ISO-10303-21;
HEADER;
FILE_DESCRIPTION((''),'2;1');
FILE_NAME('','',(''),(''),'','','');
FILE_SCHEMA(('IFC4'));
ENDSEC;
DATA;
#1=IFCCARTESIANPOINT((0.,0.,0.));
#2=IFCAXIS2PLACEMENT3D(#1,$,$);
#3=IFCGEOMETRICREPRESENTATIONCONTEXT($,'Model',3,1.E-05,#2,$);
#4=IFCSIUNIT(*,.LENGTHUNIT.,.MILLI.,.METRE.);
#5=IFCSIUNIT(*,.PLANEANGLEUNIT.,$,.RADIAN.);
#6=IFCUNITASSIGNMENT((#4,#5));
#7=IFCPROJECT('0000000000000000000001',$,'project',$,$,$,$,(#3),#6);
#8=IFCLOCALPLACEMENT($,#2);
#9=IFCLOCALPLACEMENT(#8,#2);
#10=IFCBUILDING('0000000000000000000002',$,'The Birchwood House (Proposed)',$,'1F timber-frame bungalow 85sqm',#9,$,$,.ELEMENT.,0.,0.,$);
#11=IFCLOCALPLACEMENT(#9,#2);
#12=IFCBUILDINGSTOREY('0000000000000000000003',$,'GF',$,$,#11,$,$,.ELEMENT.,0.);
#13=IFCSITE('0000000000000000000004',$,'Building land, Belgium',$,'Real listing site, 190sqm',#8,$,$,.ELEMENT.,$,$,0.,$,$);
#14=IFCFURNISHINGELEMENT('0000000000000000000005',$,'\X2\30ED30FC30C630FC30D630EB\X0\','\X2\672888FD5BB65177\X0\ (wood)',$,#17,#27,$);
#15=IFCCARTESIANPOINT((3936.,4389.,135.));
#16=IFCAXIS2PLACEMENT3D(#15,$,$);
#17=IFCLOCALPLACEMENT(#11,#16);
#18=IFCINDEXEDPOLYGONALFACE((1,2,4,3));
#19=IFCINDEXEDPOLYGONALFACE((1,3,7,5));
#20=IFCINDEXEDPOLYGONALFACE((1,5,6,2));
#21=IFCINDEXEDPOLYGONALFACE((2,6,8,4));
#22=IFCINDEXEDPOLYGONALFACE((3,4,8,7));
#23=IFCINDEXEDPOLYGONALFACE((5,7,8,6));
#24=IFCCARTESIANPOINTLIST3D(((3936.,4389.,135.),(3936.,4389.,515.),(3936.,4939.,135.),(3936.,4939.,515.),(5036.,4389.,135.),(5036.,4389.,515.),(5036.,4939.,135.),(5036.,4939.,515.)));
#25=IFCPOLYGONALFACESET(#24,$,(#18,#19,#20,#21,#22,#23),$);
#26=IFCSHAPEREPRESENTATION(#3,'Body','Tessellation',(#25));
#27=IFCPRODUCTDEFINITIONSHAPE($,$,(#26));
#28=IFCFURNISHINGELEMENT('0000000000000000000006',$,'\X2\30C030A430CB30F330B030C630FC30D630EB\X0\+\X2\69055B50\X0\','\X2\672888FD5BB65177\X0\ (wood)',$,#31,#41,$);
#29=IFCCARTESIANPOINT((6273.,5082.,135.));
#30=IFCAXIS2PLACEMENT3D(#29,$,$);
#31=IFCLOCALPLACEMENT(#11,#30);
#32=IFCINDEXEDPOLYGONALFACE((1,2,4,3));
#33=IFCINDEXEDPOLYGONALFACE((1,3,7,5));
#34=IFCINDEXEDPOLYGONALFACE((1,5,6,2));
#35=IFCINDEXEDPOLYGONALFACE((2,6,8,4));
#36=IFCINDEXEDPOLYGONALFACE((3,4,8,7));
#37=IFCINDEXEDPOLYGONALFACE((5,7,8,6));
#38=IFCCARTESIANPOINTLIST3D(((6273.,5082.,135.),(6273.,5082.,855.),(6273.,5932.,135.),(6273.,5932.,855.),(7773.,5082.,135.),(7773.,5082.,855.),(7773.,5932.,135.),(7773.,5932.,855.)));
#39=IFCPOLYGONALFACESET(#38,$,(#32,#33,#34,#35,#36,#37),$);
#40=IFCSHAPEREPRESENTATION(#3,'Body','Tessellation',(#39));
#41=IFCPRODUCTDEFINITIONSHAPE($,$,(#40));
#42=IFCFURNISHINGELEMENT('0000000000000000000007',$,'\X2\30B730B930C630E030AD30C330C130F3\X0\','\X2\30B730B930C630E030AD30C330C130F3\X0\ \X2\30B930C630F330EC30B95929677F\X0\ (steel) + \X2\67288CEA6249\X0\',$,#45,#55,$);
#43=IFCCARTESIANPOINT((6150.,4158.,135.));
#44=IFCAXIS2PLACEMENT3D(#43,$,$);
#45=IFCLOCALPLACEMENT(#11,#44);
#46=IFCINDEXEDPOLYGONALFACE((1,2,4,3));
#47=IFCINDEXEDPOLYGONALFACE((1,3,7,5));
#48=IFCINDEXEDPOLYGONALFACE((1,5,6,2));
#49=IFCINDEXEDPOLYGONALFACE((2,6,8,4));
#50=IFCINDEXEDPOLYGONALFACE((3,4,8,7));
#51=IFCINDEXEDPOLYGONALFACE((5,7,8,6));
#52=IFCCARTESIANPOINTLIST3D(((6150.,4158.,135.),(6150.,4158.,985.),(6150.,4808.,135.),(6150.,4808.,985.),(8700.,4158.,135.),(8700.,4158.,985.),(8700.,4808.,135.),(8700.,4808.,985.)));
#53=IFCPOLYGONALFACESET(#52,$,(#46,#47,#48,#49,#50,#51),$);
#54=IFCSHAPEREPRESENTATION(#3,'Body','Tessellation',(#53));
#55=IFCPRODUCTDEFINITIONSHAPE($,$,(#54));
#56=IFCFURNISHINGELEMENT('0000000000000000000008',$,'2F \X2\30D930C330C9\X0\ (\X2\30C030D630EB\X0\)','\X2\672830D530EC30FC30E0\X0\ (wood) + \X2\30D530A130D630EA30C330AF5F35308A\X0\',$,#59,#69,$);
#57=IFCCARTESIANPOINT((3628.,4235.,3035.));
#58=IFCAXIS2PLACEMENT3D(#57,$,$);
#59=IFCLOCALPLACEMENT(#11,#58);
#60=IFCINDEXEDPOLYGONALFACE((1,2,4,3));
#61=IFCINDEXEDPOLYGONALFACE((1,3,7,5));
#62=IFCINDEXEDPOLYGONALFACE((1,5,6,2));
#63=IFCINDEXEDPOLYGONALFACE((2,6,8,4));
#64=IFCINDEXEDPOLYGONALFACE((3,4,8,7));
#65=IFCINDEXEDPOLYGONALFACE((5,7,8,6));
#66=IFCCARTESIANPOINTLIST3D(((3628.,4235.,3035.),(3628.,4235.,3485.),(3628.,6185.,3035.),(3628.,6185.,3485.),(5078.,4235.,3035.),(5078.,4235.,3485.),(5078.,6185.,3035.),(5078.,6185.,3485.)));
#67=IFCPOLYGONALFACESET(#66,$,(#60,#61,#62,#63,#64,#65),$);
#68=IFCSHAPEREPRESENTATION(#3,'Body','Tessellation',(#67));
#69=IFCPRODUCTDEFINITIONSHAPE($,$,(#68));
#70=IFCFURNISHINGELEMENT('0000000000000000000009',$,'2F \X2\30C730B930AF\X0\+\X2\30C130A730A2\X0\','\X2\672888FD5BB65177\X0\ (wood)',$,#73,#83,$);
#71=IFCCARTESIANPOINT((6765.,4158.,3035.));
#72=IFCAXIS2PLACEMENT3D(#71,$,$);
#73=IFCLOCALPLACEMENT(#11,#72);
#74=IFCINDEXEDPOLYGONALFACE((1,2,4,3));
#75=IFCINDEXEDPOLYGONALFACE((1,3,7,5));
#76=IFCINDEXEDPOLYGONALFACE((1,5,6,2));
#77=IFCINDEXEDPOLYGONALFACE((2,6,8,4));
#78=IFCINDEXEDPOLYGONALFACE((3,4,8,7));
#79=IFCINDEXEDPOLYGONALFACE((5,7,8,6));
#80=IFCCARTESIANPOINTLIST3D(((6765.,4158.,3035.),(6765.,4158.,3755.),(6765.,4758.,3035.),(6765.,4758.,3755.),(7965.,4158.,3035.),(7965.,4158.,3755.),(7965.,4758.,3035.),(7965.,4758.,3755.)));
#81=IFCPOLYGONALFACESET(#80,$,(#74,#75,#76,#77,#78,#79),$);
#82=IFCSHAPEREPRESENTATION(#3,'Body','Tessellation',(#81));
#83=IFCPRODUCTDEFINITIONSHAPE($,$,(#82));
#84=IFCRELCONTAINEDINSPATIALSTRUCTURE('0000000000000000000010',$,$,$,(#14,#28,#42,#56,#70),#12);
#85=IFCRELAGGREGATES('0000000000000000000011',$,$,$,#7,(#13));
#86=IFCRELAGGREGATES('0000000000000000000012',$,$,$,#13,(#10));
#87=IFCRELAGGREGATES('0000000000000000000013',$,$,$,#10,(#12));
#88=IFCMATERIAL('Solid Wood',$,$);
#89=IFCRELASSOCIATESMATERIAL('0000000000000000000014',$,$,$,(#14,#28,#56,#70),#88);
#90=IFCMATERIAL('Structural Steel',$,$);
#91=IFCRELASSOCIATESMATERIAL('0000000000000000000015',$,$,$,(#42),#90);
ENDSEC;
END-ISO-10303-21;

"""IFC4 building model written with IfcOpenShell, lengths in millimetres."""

from ifc_helpers import new_model, si_unit, frame, frame_2d, origin, place, context, project, spatial, rectangle, extrude, material, element, save


model = new_model("IFC4")

# Units and contexts
model_context = context("Model", 3, precision=1e-05, world=origin())
ifc_project = project(units=[si_unit("LENGTHUNIT", "METRE", prefix="MILLI"), si_unit("PLANEANGLEUNIT", "RADIAN")], contexts=[model_context])

# Site, building, storey
site_placement = place(None, origin())
site = spatial("IfcSite", under=ifc_project, at=site_placement, Name="Building land, Belgium", ObjectType="Real listing site, 190sqm", CompositionType="ELEMENT", RefElevation=0.0)
building_placement = place(site_placement, origin())
building = spatial("IfcBuilding", under=site, at=building_placement, Name="The Birchwood House (Proposed)", ObjectType="1F timber-frame bungalow 85sqm", CompositionType="ELEMENT", ElevationOfRefHeight=0.0, ElevationOfTerrain=0.0)
storey_placement = place(building_placement, origin())
storey = spatial("IfcBuildingStorey", under=building, at=storey_placement, Name="GF", CompositionType="ELEMENT", Elevation=0.0)

# Shared definitions
ifc_material_1 = material(Name="Solid Wood")

# Shared definitions
ifc_material_2 = material(Name="Structural Steel")

# Furnishing elements
furnishing_1_placement = place(storey_placement, frame((3936.0, 4389.0, 135.0)))
element("IfcFurnishingElement", 1, at=furnishing_1_placement, inside=storey, material=ifc_material_1, Name="ローテーブル", Description="木製家具 (wood)", context=model_context, shape_type="SweptSolid", body=[
    extrude(rectangle(XDim=1100.0, YDim=550.0, at=frame_2d((550.0, 275.0))), frame((3936.0, 4389.0, 135.0)), (0.0, 0.0, 1.0), 380.0),
])
furnishing_2_placement = place(storey_placement, frame((6273.0, 5082.0, 135.0)))
element("IfcFurnishingElement", 2, at=furnishing_2_placement, inside=storey, material=ifc_material_1, Name="ダイニングテーブル+椅子", Description="木製家具 (wood)", context=model_context, shape_type="SweptSolid", body=[
    extrude(rectangle(XDim=1500.0, YDim=850.0, at=frame_2d((750.0, 425.0))), frame((6273.0, 5082.0, 135.0)), (0.0, 0.0, 1.0), 720.0),
])
furnishing_3_placement = place(storey_placement, frame((6150.0, 4158.0, 135.0)))
element("IfcFurnishingElement", 3, at=furnishing_3_placement, inside=storey, material=ifc_material_2, Name="システムキッチン", Description="システムキッチン ステンレス天板 (steel) + 木質扉", context=model_context, shape_type="SweptSolid", body=[
    extrude(rectangle(XDim=2550.0, YDim=650.0, at=frame_2d((1275.0, 325.0))), frame((6150.0, 4158.0, 135.0)), (0.0, 0.0, 1.0), 850.0),
])
furnishing_4_placement = place(storey_placement, frame((3628.0, 4235.0, 3035.0)))
element("IfcFurnishingElement", 4, at=furnishing_4_placement, inside=storey, material=ifc_material_1, Name="2F ベッド (ダブル)", Description="木フレーム (wood) + ファブリック張り", context=model_context, shape_type="SweptSolid", body=[
    extrude(rectangle(XDim=1450.0, YDim=1950.0, at=frame_2d((725.0, 975.0))), frame((3628.0, 4235.0, 3035.0)), (0.0, 0.0, 1.0), 450.0),
])
furnishing_5_placement = place(storey_placement, frame((6765.0, 4158.0, 3035.0)))
element("IfcFurnishingElement", 5, at=furnishing_5_placement, inside=storey, material=ifc_material_1, Name="2F デスク+チェア", Description="木製家具 (wood)", context=model_context, shape_type="SweptSolid", body=[
    extrude(rectangle(XDim=1200.0, YDim=600.0, at=frame_2d((600.0, 300.0))), frame((6765.0, 4158.0, 3035.0)), (0.0, 0.0, 1.0), 720.0),
])

save(model, "model.ifc")
